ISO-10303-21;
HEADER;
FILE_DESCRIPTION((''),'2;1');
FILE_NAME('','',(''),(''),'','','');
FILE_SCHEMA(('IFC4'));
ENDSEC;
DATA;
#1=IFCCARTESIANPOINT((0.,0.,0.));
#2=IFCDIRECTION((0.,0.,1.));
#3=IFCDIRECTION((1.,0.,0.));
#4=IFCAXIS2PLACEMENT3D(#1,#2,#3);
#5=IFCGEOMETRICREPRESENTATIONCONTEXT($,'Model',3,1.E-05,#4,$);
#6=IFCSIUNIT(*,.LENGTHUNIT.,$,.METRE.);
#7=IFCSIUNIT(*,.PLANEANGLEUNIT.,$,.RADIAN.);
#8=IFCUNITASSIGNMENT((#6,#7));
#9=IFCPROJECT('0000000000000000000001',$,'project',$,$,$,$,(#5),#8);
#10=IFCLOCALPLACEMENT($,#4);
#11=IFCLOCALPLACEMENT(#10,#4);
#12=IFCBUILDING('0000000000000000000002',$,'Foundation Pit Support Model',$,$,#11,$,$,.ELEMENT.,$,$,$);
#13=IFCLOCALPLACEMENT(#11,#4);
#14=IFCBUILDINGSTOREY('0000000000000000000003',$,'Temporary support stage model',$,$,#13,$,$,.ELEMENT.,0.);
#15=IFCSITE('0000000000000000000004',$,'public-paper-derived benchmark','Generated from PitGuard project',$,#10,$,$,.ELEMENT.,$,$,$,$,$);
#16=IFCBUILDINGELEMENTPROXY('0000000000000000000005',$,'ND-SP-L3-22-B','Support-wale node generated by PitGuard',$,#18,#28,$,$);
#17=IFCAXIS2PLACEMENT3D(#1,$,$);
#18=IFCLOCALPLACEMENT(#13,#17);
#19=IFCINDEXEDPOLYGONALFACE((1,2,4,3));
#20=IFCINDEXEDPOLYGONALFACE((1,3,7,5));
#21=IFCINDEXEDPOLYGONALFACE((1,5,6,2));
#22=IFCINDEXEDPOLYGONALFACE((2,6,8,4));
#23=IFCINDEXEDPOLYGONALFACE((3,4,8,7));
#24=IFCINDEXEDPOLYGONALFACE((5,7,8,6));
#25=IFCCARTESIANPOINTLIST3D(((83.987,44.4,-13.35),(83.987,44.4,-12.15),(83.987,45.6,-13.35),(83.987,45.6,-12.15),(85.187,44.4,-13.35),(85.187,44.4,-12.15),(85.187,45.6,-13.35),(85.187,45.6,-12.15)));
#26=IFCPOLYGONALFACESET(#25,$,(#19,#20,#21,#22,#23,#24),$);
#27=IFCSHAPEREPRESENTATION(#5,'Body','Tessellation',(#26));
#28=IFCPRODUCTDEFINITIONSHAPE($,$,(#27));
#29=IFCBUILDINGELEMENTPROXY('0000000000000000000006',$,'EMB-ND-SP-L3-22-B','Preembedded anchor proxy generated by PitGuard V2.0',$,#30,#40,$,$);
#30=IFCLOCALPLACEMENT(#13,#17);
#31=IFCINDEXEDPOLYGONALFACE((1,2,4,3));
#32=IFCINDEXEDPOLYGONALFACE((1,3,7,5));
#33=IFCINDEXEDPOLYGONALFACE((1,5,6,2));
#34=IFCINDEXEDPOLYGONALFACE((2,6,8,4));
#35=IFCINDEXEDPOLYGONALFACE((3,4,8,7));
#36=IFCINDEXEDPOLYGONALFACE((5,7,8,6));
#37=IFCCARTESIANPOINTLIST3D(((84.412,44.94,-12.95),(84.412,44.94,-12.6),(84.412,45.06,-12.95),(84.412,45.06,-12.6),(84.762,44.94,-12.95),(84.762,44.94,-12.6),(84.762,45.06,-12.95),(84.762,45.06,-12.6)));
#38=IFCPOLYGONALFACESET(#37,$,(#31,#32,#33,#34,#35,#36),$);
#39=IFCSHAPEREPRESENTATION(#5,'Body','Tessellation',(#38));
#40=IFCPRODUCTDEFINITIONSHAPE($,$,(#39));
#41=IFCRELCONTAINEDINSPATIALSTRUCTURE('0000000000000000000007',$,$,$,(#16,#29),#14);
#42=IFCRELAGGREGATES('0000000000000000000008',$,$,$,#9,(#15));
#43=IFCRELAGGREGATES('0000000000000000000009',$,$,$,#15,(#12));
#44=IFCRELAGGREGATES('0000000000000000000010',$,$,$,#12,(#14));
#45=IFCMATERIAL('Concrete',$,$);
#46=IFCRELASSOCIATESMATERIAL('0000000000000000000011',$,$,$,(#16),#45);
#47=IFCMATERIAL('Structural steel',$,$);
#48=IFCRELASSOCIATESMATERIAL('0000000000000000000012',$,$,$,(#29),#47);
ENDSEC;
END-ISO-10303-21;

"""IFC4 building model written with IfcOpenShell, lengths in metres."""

from ifc_helpers import new_model, si_unit, frame, origin_with_axes, origin_2d, place, context, project, spatial, rectangle, extrude, material, element, save


model = new_model("IFC4")

# Units and contexts
model_context = context("Model", 3, precision=1e-05, world=origin_with_axes())
ifc_project = project(units=[si_unit("LENGTHUNIT", "METRE"), si_unit("PLANEANGLEUNIT", "RADIAN")], contexts=[model_context])

# Site, building, storey
site_placement = place(None, origin_with_axes())
site = spatial("IfcSite", under=ifc_project, at=site_placement, Name="public-paper-derived benchmark", Description="Generated from PitGuard project", CompositionType="ELEMENT")
building_placement = place(site_placement, origin_with_axes())
building = spatial("IfcBuilding", under=site, at=building_placement, Name="Foundation Pit Support Model", CompositionType="ELEMENT")
storey_placement = place(building_placement, origin_with_axes())
storey = spatial("IfcBuildingStorey", under=building, at=storey_placement, Name="Temporary support stage model", CompositionType="ELEMENT", Elevation=0.0)

# Shared definitions
ifc_material_1 = material(Name="Concrete")

# Shared definitions
ifc_material_2 = material(Name="Structural steel")

# Building element proxies
proxy_1_placement = place(storey_placement, frame((84.587, 45.0, -13.35), z_axis=(0.0, 0.0, 1.0), x_axis=(1.0, 0.0, 0.0)))
element("IfcBuildingElementProxy", 1, at=proxy_1_placement, inside=storey, material=ifc_material_1, Name="ND-SP-L3-22-B", Description="Support-wale node generated by PitGuard", context=model_context, shape_type="SweptSolid", body=[
    extrude(rectangle(XDim=1.2, YDim=1.2, at=origin_2d()), origin_with_axes(), (0.0, 0.0, 1.0), 1.2),
])
proxy_2_placement = place(storey_placement, frame((84.587, 45.0, -12.95), z_axis=(0.0, 0.0, 1.0), x_axis=(1.0, 0.0, 0.0)))
element("IfcBuildingElementProxy", 2, at=proxy_2_placement, inside=storey, material=ifc_material_2, Name="EMB-ND-SP-L3-22-B", Description="Preembedded anchor proxy generated by PitGuard V2.0", context=model_context, shape_type="SweptSolid", body=[
    extrude(rectangle(XDim=0.35, YDim=0.12, at=origin_2d()), origin_with_axes(), (0.0, 0.0, 1.0), 0.35),
])

save(model, "model.ifc")
